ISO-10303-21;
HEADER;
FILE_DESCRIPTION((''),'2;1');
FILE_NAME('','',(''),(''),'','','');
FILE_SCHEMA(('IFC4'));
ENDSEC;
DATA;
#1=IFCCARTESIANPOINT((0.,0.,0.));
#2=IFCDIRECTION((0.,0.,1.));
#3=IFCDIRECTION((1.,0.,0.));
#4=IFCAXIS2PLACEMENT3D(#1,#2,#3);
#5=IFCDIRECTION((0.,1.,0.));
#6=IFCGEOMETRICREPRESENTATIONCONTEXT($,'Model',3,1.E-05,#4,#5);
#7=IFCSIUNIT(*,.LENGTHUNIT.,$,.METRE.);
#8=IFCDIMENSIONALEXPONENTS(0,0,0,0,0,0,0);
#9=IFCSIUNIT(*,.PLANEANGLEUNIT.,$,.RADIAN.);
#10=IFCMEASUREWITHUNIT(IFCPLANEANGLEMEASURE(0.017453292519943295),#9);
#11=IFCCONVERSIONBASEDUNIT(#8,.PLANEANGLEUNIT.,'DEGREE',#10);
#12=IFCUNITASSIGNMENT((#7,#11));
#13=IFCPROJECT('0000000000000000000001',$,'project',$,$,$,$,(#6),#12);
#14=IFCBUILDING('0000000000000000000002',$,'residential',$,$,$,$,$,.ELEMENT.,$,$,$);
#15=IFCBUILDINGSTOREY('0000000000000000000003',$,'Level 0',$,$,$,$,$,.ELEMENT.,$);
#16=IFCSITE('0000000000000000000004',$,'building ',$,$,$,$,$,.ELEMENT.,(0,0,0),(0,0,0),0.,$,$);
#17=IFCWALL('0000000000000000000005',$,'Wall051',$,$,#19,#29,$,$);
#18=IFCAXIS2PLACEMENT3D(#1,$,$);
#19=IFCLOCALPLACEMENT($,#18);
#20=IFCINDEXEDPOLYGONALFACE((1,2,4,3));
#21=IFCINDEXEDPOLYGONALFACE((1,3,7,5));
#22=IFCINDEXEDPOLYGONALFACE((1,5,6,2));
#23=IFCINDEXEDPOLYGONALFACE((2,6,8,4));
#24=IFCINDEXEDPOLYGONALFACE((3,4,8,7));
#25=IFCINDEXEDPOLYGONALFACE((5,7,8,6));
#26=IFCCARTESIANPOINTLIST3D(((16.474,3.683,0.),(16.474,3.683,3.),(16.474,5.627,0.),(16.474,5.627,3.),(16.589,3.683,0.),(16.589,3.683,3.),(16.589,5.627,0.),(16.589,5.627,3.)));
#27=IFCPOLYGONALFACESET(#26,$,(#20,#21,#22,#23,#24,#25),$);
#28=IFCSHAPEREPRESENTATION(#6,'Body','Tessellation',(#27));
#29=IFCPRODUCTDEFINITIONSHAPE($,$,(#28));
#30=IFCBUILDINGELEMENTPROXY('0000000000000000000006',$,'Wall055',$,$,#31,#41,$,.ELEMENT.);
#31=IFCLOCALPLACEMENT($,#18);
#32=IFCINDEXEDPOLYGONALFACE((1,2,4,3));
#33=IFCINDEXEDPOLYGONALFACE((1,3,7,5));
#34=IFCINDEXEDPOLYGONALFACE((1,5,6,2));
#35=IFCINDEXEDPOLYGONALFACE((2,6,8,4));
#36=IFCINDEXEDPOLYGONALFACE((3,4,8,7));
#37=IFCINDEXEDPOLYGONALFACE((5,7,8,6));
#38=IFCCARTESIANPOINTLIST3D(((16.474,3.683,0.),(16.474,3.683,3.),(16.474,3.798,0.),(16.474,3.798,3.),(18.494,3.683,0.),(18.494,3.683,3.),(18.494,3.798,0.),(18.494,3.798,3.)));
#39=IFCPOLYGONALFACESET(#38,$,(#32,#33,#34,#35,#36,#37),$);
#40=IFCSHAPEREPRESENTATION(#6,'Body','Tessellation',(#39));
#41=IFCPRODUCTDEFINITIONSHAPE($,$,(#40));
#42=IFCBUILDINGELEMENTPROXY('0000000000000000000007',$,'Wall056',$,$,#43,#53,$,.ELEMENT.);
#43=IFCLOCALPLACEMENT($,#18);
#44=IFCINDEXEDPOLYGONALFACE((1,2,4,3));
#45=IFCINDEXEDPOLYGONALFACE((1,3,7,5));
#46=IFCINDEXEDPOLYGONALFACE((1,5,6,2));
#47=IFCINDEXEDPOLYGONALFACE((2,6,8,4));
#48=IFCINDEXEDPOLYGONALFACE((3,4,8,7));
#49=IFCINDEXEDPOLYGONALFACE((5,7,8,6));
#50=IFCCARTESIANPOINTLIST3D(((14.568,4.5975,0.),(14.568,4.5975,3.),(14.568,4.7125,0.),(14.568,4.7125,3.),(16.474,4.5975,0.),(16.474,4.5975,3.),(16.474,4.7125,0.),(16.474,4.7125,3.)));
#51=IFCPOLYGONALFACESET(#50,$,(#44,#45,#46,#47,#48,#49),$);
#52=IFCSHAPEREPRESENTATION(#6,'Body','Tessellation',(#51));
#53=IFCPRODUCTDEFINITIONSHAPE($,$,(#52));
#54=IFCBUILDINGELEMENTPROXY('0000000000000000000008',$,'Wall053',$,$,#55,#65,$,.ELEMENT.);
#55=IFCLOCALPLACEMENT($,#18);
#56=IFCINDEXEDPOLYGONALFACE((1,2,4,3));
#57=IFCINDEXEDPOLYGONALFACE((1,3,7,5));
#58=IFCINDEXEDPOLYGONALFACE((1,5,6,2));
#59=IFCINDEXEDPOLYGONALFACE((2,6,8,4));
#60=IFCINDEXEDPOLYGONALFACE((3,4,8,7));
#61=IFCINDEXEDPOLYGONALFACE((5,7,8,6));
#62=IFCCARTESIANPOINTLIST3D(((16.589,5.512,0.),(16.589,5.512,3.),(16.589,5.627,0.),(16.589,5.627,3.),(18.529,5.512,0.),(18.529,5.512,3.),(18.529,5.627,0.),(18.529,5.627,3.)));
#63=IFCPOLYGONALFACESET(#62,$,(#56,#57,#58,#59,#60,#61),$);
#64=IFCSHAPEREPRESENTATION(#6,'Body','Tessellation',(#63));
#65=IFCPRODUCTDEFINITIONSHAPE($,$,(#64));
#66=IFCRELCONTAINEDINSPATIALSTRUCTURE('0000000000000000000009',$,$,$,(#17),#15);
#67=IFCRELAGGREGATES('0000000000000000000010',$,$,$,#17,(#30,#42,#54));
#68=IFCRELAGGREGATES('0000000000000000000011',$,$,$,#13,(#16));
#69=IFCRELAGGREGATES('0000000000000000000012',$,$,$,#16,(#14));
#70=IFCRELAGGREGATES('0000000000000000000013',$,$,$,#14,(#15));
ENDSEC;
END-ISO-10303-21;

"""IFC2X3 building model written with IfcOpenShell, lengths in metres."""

from ifc_helpers import new_model, entity, si_unit, converted_unit, direction, frame, frame_2d, origin_with_axes, place, context, project, spatial, rectangle, extrude, element, aggregate, save


model = new_model("IFC2X3")

# Units and contexts
model_context = context("Model", 3, precision=1e-05, world=origin_with_axes(), true_north=direction((0.0, 1.0, 0.0)))
ifc_project = project(units=[si_unit("LENGTHUNIT", "METRE"), converted_unit("PLANEANGLEUNIT", "DEGREE", entity("IfcPlaneAngleMeasure", 0.017453292519943295), si_unit("PLANEANGLEUNIT", "RADIAN"), dimensions=[0, 0, 0, 0, 0, 0, 0])], contexts=[model_context])

# Site, building, storey
site = spatial("IfcSite", under=ifc_project, Name="building ", CompositionType="ELEMENT", RefLatitude=(0, 0, 0), RefLongitude=(0, 0, 0), RefElevation=0.0)
building = spatial("IfcBuilding", under=site, Name="residential", CompositionType="ELEMENT")
storey = spatial("IfcBuildingStorey", under=building, Name="Level 0", CompositionType="ELEMENT")

# Shared definitions
placement = place(None, origin_with_axes())

# Wall
wall_1 = element("IfcWall", 1, at=placement, inside=storey, Name="Wall051", context=model_context, shape_type="SweptSolid", body=[
    extrude(rectangle(XDim=1.944, YDim=0.115, at=frame_2d((0.0, 0.0), x_axis=(0.0, 1.0, 0.0))), frame((16.5315, 4.655, 0.0), z_axis=(0.0, 0.0, 1.0), x_axis=(1.0, 0.0, 0.0)), (0.0, 0.0, 1.0), 3.0),
])

# Building element proxies
proxy_1 = element("IfcBuildingElementProxy", 2, at=placement, Name="Wall055", CompositionType="ELEMENT", context=model_context, shape_type="SweptSolid", body=[
    extrude(rectangle(XDim=2.02, YDim=0.115, at=frame_2d((0.0, 0.0), x_axis=(1.0, 0.0, 0.0))), frame((17.484, 3.7405, 0.0), z_axis=(0.0, 0.0, 1.0), x_axis=(1.0, 0.0, 0.0)), (0.0, 0.0, 1.0), 3.0),
])
proxy_2 = element("IfcBuildingElementProxy", 3, at=placement, Name="Wall056", CompositionType="ELEMENT", context=model_context, shape_type="SweptSolid", body=[
    extrude(rectangle(XDim=1.906, YDim=0.115, at=frame_2d((0.0, 0.0), x_axis=(-1.0, 0.0, 0.0))), frame((15.521, 4.655, 0.0), z_axis=(0.0, 0.0, 1.0), x_axis=(1.0, 0.0, 0.0)), (0.0, 0.0, 1.0), 3.0),
])
proxy_3 = element("IfcBuildingElementProxy", 4, at=placement, Name="Wall053", CompositionType="ELEMENT", context=model_context, shape_type="SweptSolid", body=[
    extrude(rectangle(XDim=1.94, YDim=0.115, at=frame_2d((0.0, 0.0), x_axis=(1.0, 0.0, 0.0))), frame((17.559, 5.5695, 0.0), z_axis=(0.0, 0.0, 1.0), x_axis=(1.0, 0.0, 0.0)), (0.0, 0.0, 1.0), 3.0),
])
aggregate(wall_1, [proxy_1, proxy_2, proxy_3])

save(model, "model.ifc")
